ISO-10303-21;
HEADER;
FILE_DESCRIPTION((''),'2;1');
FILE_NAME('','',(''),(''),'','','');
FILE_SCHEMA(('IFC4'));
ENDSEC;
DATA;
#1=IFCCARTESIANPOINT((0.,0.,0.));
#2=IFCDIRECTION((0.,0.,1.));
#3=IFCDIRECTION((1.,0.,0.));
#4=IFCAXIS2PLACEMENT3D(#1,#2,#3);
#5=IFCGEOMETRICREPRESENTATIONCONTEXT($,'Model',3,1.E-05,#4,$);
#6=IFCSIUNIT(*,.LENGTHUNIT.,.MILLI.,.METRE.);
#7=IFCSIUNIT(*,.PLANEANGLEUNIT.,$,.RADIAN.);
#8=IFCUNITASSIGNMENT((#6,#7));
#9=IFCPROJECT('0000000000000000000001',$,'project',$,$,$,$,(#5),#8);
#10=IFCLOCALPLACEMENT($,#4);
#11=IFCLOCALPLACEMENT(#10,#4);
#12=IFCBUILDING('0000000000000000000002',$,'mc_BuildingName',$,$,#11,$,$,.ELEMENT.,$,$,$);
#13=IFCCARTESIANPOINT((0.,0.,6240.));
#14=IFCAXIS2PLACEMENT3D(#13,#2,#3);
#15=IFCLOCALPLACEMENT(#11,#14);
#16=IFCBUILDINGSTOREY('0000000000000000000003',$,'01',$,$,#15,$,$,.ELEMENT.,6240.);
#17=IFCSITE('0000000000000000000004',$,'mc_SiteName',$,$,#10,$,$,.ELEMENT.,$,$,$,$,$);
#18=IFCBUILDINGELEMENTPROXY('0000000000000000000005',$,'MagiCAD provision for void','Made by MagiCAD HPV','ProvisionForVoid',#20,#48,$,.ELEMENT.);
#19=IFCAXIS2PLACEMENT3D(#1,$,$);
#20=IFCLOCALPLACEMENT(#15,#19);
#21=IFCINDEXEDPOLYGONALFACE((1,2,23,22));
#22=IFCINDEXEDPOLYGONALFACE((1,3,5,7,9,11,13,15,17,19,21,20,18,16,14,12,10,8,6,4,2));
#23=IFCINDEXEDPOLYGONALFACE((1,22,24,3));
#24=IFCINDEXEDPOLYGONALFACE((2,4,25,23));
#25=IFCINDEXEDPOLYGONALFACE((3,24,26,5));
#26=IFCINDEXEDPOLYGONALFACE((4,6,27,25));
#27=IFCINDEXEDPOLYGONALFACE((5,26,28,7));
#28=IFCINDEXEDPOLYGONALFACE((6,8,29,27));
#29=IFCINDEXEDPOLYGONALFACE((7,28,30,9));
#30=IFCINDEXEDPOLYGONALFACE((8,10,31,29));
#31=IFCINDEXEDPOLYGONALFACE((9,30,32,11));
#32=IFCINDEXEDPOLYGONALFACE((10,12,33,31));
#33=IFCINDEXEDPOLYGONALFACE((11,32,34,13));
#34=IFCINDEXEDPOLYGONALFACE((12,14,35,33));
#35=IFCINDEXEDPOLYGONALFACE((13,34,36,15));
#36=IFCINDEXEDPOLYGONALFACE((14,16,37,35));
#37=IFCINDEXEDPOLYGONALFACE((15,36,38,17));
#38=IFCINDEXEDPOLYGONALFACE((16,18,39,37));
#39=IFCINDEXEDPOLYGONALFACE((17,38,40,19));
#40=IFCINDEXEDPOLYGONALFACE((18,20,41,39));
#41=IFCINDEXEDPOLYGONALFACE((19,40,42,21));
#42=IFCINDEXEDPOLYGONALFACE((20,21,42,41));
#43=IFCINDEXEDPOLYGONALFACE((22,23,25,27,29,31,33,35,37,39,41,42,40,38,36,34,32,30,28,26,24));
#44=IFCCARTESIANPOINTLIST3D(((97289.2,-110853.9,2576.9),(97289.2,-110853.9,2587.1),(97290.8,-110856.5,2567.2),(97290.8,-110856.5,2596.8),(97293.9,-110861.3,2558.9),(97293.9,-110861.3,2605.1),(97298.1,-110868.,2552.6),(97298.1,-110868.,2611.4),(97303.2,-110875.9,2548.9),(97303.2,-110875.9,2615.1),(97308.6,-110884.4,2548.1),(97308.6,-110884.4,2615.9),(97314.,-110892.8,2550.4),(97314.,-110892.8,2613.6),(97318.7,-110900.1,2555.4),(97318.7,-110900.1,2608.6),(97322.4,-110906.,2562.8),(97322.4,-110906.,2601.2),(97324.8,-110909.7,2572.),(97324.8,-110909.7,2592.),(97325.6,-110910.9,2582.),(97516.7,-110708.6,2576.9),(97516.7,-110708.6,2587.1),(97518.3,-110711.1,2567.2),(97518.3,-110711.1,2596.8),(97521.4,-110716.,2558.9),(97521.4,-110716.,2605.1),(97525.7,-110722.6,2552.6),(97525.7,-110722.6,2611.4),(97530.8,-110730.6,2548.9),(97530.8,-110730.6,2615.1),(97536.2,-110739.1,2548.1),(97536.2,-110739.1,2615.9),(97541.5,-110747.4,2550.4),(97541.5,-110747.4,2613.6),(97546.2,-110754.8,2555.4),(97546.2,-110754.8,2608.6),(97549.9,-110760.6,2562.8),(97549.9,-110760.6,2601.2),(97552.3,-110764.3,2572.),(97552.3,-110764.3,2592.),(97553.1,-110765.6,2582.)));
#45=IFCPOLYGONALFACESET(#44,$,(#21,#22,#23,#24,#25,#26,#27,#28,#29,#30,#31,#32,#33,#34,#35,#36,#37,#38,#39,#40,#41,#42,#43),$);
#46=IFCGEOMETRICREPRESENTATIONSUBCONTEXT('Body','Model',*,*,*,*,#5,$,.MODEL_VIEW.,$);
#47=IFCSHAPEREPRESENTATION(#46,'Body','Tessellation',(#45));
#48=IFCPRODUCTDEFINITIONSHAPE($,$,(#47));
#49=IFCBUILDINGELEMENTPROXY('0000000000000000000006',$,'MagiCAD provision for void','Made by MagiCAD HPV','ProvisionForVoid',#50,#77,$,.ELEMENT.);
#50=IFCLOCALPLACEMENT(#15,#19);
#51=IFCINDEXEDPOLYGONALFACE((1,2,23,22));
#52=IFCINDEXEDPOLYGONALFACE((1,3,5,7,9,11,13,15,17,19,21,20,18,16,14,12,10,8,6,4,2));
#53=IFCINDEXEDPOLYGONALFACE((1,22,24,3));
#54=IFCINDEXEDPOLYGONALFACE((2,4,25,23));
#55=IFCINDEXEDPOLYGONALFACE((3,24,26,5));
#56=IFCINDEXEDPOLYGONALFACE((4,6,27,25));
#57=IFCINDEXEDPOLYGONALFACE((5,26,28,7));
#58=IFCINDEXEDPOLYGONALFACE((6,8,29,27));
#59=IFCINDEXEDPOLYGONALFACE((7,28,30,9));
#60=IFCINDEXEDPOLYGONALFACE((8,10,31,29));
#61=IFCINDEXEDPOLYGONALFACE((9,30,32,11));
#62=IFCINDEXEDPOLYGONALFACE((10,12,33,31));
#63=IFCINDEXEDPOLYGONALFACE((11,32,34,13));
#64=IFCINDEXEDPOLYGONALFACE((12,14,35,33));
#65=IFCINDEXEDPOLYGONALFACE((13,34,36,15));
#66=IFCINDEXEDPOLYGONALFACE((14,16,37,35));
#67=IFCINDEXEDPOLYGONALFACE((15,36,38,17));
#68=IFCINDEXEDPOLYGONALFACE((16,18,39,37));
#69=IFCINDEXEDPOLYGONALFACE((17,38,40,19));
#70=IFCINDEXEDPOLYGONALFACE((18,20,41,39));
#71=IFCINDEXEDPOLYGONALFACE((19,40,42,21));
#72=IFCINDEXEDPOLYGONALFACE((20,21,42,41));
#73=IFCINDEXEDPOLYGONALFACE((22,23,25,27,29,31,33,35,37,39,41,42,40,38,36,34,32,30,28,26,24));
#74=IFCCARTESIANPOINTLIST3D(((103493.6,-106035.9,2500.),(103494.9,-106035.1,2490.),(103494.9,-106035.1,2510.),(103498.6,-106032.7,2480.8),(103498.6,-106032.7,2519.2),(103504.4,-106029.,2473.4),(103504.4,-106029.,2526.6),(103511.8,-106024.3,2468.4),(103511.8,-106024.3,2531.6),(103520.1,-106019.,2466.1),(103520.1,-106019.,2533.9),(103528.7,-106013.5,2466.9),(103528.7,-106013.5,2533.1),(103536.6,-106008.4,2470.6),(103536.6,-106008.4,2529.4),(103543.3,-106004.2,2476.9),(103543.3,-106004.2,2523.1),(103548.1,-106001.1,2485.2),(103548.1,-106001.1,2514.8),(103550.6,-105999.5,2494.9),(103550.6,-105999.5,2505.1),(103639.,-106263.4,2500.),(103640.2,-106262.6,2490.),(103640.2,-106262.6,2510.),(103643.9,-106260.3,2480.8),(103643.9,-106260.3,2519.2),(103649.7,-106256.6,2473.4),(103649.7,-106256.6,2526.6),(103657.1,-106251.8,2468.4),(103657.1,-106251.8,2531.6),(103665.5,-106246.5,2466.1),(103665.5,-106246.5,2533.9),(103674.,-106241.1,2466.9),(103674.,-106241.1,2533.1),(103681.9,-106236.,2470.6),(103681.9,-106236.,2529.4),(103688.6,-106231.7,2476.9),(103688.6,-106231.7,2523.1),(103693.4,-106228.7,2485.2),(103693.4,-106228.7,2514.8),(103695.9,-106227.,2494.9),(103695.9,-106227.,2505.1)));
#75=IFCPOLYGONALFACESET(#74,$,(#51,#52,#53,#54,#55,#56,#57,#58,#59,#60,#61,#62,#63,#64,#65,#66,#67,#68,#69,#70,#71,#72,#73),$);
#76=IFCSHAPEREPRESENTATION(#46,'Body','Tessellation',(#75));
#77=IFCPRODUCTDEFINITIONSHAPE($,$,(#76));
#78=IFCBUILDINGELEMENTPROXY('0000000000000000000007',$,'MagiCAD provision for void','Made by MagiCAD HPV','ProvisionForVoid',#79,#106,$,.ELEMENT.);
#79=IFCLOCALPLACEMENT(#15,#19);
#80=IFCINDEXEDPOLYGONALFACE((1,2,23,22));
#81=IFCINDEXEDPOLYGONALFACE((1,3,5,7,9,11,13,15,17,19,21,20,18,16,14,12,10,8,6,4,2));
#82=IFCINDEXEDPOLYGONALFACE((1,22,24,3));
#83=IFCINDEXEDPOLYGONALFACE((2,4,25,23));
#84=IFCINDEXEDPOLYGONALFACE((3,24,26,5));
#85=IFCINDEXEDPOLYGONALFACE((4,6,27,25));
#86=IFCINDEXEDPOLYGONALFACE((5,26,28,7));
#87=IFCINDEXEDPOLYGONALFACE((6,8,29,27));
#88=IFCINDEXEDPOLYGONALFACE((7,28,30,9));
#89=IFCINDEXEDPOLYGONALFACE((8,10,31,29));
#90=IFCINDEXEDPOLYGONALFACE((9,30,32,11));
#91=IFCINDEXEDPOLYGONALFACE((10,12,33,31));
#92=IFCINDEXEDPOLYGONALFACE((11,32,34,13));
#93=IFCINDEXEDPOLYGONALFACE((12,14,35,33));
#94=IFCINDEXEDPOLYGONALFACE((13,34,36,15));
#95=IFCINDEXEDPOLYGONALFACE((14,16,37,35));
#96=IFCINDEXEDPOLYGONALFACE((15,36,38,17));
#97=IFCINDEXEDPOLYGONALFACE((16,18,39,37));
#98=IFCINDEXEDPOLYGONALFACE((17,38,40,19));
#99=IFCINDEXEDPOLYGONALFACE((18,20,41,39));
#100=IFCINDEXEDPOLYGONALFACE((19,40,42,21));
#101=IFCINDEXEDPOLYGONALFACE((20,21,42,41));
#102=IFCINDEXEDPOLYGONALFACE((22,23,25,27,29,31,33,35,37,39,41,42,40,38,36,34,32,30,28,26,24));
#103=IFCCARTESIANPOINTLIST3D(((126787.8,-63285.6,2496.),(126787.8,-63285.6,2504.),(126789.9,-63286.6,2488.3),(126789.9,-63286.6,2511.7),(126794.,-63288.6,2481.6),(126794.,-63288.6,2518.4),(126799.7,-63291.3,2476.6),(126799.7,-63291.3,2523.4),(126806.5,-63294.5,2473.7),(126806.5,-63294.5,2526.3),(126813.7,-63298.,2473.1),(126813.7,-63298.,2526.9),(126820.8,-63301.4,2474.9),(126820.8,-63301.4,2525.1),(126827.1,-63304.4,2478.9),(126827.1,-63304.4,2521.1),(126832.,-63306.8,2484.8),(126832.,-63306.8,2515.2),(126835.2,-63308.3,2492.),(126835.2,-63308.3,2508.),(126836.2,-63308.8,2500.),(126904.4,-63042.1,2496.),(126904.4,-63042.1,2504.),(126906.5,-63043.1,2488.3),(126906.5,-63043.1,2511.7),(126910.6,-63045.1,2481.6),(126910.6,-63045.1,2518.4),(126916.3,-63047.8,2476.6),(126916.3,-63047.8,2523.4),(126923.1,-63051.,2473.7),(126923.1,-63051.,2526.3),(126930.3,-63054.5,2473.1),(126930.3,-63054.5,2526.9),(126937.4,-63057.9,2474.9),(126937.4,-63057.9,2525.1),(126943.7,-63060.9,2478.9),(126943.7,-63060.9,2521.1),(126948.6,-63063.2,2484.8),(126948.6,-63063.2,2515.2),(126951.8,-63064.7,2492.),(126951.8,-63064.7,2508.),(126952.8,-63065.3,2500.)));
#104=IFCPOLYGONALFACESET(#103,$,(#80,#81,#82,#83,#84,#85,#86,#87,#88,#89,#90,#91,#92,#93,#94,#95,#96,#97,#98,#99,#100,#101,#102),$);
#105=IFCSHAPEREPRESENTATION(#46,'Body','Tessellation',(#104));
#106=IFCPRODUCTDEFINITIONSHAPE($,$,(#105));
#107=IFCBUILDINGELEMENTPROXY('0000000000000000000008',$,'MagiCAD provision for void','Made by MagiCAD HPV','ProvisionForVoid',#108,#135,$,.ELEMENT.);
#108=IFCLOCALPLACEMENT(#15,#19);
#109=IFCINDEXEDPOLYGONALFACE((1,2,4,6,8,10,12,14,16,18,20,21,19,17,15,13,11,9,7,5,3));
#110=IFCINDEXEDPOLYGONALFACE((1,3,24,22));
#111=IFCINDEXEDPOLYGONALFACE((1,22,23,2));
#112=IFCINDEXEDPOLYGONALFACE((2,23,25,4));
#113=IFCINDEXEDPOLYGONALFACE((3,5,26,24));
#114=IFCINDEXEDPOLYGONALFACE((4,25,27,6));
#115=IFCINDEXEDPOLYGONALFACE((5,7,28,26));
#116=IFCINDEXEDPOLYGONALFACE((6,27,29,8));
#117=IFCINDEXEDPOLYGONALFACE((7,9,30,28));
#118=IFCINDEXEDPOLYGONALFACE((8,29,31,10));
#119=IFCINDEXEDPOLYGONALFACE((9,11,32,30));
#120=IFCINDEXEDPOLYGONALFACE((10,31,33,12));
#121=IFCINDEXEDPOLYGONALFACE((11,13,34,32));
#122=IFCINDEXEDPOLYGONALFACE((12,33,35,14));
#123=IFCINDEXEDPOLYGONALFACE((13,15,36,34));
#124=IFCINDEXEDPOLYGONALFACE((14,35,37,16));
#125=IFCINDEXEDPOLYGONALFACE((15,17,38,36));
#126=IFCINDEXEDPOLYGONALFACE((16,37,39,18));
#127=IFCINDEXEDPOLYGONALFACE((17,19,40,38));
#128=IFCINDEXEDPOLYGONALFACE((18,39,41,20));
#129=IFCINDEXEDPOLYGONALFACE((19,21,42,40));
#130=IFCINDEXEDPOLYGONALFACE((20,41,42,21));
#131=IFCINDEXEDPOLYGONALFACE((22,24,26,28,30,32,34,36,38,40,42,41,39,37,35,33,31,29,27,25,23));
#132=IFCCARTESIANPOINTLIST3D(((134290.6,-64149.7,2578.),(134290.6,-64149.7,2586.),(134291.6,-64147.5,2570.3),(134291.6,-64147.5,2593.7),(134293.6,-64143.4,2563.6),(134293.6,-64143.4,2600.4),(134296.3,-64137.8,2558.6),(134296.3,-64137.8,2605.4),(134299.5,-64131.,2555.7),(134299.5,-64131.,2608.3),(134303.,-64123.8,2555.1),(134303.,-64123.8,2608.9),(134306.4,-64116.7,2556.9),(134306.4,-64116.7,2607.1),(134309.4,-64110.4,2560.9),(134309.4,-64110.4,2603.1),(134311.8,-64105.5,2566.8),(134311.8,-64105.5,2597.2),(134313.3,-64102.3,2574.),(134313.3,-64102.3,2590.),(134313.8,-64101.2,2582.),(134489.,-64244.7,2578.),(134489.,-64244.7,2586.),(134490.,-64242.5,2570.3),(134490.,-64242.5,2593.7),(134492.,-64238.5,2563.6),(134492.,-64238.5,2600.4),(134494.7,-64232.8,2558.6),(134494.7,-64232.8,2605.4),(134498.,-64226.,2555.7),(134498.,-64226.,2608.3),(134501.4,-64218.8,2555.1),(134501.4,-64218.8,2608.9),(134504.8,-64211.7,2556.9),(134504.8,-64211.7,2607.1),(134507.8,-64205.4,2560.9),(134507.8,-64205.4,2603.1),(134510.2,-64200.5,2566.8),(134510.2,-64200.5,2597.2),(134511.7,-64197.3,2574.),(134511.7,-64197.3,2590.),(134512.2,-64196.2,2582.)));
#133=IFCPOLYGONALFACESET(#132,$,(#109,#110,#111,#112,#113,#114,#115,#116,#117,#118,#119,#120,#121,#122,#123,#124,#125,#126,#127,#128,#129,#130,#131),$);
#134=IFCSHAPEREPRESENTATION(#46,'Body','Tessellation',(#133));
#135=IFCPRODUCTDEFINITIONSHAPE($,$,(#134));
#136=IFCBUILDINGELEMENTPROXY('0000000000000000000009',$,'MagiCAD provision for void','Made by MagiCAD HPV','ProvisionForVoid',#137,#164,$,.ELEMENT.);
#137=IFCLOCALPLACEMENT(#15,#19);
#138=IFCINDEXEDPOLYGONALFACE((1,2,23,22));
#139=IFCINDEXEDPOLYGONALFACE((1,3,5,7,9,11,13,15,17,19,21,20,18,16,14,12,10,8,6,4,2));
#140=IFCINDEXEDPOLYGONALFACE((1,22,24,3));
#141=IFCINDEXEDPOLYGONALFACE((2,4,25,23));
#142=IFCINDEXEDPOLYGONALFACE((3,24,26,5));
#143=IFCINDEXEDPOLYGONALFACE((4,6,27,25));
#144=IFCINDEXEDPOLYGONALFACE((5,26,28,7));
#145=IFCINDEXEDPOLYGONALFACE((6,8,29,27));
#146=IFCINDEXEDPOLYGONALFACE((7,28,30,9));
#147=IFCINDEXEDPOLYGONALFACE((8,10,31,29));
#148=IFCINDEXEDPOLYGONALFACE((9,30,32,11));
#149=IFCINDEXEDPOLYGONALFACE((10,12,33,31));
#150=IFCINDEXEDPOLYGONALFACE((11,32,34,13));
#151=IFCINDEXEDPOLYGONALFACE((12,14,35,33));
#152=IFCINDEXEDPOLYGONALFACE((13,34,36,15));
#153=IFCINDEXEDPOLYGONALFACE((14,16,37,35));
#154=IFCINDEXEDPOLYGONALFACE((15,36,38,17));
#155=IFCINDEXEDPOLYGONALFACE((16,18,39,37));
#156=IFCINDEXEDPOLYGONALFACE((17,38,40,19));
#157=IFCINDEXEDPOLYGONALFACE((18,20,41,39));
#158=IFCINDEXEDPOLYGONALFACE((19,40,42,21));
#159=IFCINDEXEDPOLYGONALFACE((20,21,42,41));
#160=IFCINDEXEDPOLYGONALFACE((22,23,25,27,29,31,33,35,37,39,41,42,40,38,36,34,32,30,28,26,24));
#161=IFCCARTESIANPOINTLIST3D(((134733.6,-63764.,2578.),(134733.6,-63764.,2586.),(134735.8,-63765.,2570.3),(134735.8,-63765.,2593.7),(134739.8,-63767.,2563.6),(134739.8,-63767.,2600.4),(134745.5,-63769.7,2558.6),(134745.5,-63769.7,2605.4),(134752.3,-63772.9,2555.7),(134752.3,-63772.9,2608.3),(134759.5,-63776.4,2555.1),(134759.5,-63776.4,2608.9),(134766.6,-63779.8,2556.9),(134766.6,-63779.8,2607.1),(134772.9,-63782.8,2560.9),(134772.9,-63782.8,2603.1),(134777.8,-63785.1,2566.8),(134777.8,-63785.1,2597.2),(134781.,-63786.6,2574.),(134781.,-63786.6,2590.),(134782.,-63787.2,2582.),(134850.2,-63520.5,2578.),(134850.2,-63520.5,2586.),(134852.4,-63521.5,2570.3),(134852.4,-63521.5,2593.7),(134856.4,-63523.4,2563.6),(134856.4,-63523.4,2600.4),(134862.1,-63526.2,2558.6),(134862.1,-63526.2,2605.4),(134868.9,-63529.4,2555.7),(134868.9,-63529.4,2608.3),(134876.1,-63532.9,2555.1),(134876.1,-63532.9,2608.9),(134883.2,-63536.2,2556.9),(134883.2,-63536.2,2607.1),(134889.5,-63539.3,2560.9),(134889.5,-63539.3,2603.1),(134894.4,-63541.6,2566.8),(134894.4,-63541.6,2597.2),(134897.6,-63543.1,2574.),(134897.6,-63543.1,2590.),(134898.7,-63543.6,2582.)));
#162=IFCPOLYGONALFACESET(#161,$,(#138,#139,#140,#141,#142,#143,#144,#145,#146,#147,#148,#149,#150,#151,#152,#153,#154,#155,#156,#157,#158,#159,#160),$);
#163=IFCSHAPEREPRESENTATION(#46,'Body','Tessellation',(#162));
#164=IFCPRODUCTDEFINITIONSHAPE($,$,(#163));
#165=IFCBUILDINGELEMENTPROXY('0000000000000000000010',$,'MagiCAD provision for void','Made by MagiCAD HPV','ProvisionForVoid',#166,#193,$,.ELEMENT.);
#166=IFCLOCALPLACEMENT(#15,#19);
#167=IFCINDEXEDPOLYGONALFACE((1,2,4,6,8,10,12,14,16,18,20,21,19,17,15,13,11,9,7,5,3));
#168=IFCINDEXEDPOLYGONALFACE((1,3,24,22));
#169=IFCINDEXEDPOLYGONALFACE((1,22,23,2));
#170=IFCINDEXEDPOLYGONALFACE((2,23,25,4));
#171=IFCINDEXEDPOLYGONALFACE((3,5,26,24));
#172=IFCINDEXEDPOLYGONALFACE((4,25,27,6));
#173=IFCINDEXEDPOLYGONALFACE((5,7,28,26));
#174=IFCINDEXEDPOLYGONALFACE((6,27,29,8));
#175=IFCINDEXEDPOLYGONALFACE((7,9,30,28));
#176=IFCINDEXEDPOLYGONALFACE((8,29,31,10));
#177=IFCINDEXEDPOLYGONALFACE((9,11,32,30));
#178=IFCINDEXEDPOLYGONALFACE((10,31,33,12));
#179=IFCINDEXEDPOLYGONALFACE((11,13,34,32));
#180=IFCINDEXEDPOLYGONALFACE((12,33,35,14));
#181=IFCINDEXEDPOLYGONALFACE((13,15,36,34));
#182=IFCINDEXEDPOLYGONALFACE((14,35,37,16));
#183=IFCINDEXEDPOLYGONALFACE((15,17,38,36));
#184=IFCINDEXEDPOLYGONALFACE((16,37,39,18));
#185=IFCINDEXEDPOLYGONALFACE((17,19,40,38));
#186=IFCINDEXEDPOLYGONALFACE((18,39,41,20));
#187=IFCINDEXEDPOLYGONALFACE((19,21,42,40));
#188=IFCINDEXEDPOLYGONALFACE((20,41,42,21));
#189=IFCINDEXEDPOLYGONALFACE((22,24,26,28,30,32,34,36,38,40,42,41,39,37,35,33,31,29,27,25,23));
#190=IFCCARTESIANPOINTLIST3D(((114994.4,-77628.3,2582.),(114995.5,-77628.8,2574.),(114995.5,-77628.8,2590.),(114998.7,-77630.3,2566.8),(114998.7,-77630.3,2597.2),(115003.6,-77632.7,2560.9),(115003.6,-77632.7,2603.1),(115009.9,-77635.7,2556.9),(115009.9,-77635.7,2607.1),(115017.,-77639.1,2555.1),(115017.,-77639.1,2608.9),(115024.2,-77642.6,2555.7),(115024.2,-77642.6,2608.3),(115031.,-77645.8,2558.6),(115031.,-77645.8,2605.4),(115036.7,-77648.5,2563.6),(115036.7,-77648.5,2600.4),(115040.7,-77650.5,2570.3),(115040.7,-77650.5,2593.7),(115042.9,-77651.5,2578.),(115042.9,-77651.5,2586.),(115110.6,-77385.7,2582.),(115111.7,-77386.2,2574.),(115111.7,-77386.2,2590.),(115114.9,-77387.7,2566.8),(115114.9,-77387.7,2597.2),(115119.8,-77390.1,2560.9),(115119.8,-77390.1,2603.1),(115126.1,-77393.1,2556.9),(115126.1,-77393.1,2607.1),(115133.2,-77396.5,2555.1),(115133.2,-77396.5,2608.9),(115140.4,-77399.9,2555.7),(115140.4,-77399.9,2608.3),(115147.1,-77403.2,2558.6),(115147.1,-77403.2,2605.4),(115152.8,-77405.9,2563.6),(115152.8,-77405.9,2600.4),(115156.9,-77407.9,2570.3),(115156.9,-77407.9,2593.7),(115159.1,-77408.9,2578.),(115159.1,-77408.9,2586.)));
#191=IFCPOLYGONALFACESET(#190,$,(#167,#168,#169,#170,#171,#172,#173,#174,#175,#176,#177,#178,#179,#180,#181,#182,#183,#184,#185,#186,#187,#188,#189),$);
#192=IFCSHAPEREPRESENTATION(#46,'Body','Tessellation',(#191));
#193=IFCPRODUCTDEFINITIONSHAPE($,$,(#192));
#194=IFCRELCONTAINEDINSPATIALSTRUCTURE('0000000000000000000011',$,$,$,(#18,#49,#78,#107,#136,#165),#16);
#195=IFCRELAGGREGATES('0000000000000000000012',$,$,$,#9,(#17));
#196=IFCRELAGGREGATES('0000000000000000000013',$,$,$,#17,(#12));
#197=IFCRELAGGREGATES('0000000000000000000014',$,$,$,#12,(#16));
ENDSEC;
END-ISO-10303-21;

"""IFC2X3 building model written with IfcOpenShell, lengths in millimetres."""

from ifc_helpers import new_model, si_unit, frame, origin_with_axes, origin_2d_with_axis, place, context, subcontext, project, spatial, circle, extrude, source, transform, mapped, element, save


model = new_model("IFC2X3")

# Units and contexts
model_context = context("Model", 3, precision=1e-05, world=origin_with_axes())
body_context = subcontext(model_context, "Body", "Model", "MODEL_VIEW")
ifc_project = project(units=[si_unit("LENGTHUNIT", "METRE", prefix="MILLI"), si_unit("PLANEANGLEUNIT", "RADIAN")], contexts=[model_context])

# Site, building, storey
site_placement = place(None, origin_with_axes())
site = spatial("IfcSite", under=ifc_project, at=site_placement, Name="mc_SiteName", CompositionType="ELEMENT")
building_placement = place(site_placement, origin_with_axes())
building = spatial("IfcBuilding", under=site, at=building_placement, Name="mc_BuildingName", CompositionType="ELEMENT")
storey_placement = place(building_placement, frame((0.0, 0.0, 6240.0), z_axis=(0.0, 0.0, 1.0), x_axis=(1.0, 0.0, 0.0)))
storey = spatial("IfcBuildingStorey", under=building, at=storey_placement, Name="01", CompositionType="ELEMENT", Elevation=6240.0)

# Building element proxies
shared_shape_1 = source(origin_with_axes(), body_context, "Body", "SweptSolid", [
    extrude(circle(Radius=34.0, at=origin_2d_with_axis()), frame((0.0, 0.0, 0.0), z_axis=(1.0, 0.0, 0.0), x_axis=(0.0, 1.0, 0.0)), (0.0, 0.0, 1.0), 270.0),
])
proxy_1_placement = place(storey_placement, frame((97534.8, -110737.0, 2582.0), z_axis=(0.0, 0.0, 1.0), x_axis=(-0.842809, -0.538213, 0.0)))
element("IfcBuildingElementProxy", 1, at=proxy_1_placement, inside=storey, Name="MagiCAD provision for void", Description="Made by MagiCAD HPV", ObjectType="ProvisionForVoid", CompositionType="ELEMENT", context=body_context, shape_type="MappedRepresentation", body=[
    mapped(shared_shape_1, transform((0.0, 0.0, 0.0), scale=1.0)),
])
shared_shape_2 = source(origin_with_axes(), body_context, "Body", "SweptSolid", [
    extrude(circle(Radius=34.0, at=origin_2d_with_axis()), frame((0.0, 0.0, 0.0), z_axis=(1.0, 0.0, 0.0), x_axis=(0.0, 1.0, 0.0)), (0.0, 0.0, 1.0), 270.0),
])
proxy_2_placement = place(storey_placement, frame((103667.6, -106245.1, 2500.0), z_axis=(0.0, 0.0, 1.0), x_axis=(-0.538213, 0.842809, 0.0)))
element("IfcBuildingElementProxy", 2, at=proxy_2_placement, inside=storey, Name="MagiCAD provision for void", Description="Made by MagiCAD HPV", ObjectType="ProvisionForVoid", CompositionType="ELEMENT", context=body_context, shape_type="MappedRepresentation", body=[
    mapped(shared_shape_2, transform((0.0, 0.0, 0.0), scale=1.0)),
])
shared_shape_3 = source(origin_with_axes(), body_context, "Body", "SweptSolid", [
    extrude(circle(Radius=27.0, at=origin_2d_with_axis()), frame((0.0, 0.0, 0.0), z_axis=(1.0, 0.0, 0.0), x_axis=(0.0, 1.0, 0.0)), (0.0, 0.0, 1.0), 270.0),
])
proxy_3_placement = place(storey_placement, frame((126928.5, -63053.6, 2500.0), z_axis=(0.0, 0.0, 1.0), x_axis=(-0.431863, -0.901939, 0.0)))
element("IfcBuildingElementProxy", 3, at=proxy_3_placement, inside=storey, Name="MagiCAD provision for void", Description="Made by MagiCAD HPV", ObjectType="ProvisionForVoid", CompositionType="ELEMENT", context=body_context, shape_type="MappedRepresentation", body=[
    mapped(shared_shape_3, transform((0.0, 0.0, 0.0), scale=1.0)),
])
shared_shape_4 = source(origin_with_axes(), body_context, "Body", "SweptSolid", [
    extrude(circle(Radius=27.0, at=origin_2d_with_axis()), frame((0.0, 0.0, 0.0), z_axis=(1.0, 0.0, 0.0), x_axis=(0.0, 1.0, 0.0)), (0.0, 0.0, 1.0), 220.0),
])
proxy_4_placement = place(storey_placement, frame((134302.1, -64125.6, 2582.0), z_axis=(0.0, 0.0, 1.0), x_axis=(0.901941, -0.431859, 0.0)))
element("IfcBuildingElementProxy", 4, at=proxy_4_placement, inside=storey, Name="MagiCAD provision for void", Description="Made by MagiCAD HPV", ObjectType="ProvisionForVoid", CompositionType="ELEMENT", context=body_context, shape_type="MappedRepresentation", body=[
    mapped(shared_shape_4, transform((0.0, 0.0, 0.0), scale=1.0)),
])
shared_shape_5 = source(origin_with_axes(), body_context, "Body", "SweptSolid", [
    extrude(circle(Radius=27.0, at=origin_2d_with_axis()), frame((0.0, 0.0, 0.0), z_axis=(1.0, 0.0, 0.0), x_axis=(0.0, 1.0, 0.0)), (0.0, 0.0, 1.0), 270.0),
])
proxy_5_placement = place(storey_placement, frame((134874.3, -63532.0, 2582.0), z_axis=(0.0, 0.0, 1.0), x_axis=(-0.431882, -0.90193, 0.0)))
element("IfcBuildingElementProxy", 5, at=proxy_5_placement, inside=storey, Name="MagiCAD provision for void", Description="Made by MagiCAD HPV", ObjectType="ProvisionForVoid", CompositionType="ELEMENT", context=body_context, shape_type="MappedRepresentation", body=[
    mapped(shared_shape_5, transform((0.0, 0.0, 0.0), scale=1.0)),
])
shared_shape_6 = source(origin_with_axes(), body_context, "Body", "SweptSolid", [
    extrude(circle(Radius=27.0, at=origin_2d_with_axis()), frame((0.0, 0.0, 0.0), z_axis=(1.0, 0.0, 0.0), x_axis=(0.0, 1.0, 0.0)), (0.0, 0.0, 1.0), 269.0),
])
proxy_6_placement = place(storey_placement, frame((115018.8, -77640.0, 2582.0), z_axis=(0.0, 0.0, 1.0), x_axis=(0.431859, 0.901941, 0.0)))
element("IfcBuildingElementProxy", 6, at=proxy_6_placement, inside=storey, Name="MagiCAD provision for void", Description="Made by MagiCAD HPV", ObjectType="ProvisionForVoid", CompositionType="ELEMENT", context=body_context, shape_type="MappedRepresentation", body=[
    mapped(shared_shape_6, transform((0.0, 0.0, 0.0), scale=1.0)),
])

save(model, "model.ifc")
